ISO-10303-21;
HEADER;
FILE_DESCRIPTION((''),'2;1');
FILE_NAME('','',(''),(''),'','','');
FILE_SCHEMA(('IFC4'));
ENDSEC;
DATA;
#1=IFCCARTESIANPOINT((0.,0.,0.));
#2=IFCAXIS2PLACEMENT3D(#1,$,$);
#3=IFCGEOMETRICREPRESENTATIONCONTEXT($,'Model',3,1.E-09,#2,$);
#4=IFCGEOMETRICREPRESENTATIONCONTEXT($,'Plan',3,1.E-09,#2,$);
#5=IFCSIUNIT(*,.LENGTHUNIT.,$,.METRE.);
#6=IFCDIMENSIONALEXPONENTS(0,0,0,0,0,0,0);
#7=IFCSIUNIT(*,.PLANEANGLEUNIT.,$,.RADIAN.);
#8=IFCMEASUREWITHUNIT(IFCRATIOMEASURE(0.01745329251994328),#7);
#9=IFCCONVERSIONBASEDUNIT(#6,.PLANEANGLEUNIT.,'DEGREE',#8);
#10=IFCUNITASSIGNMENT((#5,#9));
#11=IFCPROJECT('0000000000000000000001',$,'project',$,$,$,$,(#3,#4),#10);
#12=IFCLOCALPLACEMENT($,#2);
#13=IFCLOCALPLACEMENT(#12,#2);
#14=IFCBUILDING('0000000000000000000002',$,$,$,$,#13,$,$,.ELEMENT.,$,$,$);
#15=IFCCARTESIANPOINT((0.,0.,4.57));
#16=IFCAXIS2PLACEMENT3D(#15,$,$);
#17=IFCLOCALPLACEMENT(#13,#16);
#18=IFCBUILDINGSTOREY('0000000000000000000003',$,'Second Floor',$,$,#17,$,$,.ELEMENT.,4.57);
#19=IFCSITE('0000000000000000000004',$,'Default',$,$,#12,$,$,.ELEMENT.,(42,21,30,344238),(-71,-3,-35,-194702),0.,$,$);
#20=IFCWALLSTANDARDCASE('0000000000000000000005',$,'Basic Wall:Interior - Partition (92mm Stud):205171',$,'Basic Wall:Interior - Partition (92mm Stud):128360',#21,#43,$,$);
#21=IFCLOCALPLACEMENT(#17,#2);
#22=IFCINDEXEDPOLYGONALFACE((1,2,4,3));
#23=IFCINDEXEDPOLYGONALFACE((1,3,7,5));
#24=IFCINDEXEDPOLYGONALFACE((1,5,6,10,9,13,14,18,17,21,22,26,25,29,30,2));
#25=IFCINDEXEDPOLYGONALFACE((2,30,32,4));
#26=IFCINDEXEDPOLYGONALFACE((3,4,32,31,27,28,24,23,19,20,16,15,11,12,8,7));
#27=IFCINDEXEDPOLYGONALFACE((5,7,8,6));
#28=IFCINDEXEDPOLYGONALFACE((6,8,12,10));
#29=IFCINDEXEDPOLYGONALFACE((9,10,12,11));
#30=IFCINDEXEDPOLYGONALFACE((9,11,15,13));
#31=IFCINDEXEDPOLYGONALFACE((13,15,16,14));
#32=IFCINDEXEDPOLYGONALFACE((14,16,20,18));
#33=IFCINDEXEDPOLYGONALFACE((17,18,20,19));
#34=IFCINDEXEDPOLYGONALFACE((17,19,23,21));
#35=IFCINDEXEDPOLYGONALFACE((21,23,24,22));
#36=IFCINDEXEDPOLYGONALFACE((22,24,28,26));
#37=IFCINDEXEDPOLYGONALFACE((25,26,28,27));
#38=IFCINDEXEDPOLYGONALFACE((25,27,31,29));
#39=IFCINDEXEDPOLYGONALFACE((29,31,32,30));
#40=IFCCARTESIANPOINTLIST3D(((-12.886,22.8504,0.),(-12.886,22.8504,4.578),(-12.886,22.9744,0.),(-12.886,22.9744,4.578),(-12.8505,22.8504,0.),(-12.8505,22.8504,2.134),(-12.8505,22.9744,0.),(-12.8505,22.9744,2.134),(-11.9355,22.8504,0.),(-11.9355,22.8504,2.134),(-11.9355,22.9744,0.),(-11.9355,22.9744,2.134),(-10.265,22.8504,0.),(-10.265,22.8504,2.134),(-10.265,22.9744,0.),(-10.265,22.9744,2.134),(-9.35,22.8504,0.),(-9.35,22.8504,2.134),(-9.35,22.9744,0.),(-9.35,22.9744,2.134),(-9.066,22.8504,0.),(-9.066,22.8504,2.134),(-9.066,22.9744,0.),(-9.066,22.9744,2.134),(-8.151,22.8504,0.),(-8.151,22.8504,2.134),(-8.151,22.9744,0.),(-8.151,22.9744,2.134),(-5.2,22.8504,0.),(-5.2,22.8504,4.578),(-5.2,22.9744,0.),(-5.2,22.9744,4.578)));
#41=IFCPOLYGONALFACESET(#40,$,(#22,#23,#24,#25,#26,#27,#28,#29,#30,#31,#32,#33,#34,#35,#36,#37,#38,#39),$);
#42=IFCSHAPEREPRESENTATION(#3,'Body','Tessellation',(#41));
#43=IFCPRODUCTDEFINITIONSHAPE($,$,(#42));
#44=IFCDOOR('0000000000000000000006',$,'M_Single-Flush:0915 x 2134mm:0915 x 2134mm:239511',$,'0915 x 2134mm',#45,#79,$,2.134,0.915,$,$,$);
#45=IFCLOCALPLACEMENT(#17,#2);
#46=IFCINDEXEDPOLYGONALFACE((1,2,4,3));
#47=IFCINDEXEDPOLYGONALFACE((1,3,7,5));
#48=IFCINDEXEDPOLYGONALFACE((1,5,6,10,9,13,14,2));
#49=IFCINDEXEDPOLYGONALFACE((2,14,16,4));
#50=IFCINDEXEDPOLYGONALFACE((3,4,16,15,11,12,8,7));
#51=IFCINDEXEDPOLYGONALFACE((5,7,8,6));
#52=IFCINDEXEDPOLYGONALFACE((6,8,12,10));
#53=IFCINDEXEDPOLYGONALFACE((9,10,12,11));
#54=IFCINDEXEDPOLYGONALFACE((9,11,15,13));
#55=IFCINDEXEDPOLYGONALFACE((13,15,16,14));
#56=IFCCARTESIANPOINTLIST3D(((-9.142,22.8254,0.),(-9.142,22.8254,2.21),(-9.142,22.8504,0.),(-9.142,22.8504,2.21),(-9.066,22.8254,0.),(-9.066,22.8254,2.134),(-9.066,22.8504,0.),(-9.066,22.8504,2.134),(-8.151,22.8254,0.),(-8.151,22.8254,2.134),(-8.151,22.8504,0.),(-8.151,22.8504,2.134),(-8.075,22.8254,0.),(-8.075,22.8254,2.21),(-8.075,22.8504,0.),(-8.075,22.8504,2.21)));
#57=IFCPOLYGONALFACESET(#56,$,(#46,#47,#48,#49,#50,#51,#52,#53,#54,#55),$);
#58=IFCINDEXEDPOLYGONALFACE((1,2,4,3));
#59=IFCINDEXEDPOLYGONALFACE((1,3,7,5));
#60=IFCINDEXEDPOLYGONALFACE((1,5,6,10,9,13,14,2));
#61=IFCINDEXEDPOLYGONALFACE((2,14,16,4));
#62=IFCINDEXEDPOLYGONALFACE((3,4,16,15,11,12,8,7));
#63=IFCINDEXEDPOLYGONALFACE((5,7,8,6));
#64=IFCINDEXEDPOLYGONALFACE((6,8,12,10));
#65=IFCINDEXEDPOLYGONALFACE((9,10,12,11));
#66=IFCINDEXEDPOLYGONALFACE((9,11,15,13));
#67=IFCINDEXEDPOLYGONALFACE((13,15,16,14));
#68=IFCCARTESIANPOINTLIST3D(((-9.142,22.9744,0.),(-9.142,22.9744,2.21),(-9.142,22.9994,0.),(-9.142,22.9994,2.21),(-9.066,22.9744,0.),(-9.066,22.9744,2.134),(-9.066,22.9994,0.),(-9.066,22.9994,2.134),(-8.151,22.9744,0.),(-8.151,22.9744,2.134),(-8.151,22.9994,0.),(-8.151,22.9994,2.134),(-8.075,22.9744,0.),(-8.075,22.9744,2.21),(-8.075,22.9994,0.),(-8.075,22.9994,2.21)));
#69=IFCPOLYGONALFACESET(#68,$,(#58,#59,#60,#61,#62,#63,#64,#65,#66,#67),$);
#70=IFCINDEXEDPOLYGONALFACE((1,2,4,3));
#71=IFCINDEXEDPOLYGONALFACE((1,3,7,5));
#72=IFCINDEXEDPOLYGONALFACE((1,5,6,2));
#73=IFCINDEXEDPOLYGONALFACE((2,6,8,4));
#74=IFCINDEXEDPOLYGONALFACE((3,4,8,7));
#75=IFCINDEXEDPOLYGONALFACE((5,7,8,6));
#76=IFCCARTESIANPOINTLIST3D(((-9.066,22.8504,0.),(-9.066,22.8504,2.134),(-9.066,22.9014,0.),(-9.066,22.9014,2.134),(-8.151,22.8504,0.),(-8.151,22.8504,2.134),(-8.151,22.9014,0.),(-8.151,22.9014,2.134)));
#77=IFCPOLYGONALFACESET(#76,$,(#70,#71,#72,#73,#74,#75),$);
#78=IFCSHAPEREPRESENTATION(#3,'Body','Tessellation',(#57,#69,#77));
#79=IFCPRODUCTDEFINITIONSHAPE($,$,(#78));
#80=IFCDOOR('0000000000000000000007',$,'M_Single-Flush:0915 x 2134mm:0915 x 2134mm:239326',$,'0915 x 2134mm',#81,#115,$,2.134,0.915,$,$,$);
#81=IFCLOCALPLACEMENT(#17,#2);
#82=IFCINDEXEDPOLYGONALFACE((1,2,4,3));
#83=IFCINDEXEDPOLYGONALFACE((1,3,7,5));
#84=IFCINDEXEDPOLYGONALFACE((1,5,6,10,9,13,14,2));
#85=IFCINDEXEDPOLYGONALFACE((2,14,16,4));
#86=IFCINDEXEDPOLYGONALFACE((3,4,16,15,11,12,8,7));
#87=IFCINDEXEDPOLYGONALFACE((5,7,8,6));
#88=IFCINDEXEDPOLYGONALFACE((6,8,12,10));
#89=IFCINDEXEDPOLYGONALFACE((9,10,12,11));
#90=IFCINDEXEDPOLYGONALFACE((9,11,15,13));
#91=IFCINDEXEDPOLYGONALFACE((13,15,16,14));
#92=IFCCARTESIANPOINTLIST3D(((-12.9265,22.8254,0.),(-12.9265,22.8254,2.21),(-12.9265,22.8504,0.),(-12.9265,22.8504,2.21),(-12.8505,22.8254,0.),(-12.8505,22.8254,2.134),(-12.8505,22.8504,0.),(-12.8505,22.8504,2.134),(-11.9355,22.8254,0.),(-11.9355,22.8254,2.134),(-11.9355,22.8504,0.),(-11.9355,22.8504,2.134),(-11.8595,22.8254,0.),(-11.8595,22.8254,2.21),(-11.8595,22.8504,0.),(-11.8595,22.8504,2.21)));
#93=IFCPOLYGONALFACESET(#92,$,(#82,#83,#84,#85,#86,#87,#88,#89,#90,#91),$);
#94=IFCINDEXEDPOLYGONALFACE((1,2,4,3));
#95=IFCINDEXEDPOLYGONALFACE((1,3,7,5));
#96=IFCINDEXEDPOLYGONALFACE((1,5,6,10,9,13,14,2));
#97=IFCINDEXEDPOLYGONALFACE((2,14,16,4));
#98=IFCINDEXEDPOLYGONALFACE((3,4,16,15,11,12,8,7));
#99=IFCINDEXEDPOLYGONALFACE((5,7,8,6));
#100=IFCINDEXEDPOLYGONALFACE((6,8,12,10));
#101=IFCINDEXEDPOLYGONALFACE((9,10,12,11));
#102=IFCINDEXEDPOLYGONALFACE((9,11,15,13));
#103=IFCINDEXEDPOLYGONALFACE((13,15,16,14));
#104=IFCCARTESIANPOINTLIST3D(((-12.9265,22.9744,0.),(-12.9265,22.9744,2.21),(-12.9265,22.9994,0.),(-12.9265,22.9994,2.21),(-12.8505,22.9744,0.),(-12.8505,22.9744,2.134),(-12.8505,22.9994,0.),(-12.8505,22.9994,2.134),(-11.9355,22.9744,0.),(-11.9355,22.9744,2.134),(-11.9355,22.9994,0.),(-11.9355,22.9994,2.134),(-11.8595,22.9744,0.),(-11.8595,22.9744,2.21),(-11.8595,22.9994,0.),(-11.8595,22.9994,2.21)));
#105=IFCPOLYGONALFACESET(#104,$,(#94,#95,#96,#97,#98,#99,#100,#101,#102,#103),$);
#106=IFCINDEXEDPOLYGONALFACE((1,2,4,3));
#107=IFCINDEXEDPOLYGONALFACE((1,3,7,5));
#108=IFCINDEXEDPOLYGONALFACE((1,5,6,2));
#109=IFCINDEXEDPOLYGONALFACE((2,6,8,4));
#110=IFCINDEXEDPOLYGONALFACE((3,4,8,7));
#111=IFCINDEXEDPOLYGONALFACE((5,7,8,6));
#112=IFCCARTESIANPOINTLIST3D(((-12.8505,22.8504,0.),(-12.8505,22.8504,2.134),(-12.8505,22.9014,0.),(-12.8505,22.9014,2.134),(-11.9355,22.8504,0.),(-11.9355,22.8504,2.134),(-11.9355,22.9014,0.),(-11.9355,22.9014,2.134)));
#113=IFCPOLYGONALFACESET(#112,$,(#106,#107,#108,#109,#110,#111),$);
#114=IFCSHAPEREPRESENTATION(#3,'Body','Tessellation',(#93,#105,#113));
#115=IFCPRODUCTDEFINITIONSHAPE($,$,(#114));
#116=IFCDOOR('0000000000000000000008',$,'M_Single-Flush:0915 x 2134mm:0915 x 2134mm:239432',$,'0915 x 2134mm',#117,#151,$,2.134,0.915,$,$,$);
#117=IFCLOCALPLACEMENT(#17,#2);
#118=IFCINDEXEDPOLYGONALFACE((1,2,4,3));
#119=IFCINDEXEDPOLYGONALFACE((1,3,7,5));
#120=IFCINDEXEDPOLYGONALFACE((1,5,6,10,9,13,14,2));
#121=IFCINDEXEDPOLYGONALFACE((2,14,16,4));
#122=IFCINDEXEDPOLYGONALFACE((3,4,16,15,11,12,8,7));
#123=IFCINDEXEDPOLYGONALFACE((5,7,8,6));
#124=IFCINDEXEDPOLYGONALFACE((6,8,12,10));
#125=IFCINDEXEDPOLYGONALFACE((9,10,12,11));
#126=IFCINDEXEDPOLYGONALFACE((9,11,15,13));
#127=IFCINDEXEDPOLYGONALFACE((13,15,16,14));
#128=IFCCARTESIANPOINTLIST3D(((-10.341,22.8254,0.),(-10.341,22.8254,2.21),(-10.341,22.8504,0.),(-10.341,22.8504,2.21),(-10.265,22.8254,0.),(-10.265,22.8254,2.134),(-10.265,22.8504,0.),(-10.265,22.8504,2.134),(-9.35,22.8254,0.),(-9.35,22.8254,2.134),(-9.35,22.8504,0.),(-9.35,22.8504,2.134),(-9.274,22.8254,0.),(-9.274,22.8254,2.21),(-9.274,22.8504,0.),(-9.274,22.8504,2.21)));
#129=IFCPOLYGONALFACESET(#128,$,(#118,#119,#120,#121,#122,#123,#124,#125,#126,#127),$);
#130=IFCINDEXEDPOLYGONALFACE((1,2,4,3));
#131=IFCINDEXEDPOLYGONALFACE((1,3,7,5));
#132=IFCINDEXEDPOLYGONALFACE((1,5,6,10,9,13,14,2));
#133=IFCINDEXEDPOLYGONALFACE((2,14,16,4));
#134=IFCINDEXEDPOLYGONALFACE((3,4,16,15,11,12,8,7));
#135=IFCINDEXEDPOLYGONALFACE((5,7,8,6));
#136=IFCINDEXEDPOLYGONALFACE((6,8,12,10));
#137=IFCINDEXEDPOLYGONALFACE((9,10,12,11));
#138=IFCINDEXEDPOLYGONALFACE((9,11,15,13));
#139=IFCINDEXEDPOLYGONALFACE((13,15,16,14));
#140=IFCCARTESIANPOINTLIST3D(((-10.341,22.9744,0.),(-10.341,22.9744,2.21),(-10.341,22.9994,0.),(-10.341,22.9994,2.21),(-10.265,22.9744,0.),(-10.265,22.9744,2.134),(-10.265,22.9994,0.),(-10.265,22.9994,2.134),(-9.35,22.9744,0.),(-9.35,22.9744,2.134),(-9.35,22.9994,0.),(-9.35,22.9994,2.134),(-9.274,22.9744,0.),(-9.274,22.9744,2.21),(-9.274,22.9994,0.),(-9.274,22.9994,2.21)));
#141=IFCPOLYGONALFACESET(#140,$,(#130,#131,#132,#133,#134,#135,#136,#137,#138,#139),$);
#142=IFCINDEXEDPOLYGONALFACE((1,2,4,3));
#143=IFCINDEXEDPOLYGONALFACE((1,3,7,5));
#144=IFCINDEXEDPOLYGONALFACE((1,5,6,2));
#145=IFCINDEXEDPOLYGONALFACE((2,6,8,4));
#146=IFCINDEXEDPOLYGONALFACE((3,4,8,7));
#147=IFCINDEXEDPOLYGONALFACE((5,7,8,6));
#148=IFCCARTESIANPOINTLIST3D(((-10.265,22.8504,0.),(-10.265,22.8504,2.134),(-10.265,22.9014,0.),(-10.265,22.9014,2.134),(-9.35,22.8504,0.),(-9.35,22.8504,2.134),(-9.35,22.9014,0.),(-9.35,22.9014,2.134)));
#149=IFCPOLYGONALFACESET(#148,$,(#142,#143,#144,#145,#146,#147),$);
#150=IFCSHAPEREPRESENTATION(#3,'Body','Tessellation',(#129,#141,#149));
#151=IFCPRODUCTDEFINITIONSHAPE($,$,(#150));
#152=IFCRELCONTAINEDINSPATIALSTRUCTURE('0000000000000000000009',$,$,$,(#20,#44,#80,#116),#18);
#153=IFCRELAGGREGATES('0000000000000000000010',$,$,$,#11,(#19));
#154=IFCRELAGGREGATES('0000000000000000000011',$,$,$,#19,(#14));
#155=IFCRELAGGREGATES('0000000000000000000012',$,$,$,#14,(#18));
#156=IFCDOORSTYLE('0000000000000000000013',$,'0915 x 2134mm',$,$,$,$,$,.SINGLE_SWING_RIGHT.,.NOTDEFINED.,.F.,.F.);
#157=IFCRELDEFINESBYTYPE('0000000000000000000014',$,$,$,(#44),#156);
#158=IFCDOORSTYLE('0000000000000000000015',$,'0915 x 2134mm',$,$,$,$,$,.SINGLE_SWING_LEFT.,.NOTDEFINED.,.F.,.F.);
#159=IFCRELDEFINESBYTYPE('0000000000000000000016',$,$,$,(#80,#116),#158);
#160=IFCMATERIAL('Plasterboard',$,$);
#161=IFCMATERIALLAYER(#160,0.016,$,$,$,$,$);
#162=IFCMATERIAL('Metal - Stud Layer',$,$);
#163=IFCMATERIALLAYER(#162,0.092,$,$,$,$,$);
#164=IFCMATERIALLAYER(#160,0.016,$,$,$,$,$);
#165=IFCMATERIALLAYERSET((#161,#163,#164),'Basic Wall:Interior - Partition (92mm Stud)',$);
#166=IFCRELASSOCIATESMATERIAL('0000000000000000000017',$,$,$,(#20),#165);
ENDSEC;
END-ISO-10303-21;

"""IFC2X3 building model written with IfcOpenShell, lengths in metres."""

from ifc_helpers import new_model, entity, si_unit, converted_unit, frame, frame_2d, origin, origin_2d_with_axis, place, context, project, spatial, polyline, rectangle, outline, extrude, source, transform, mapped, material, layer, layer_set, layer_usage, type_object, type_shapes, element, fill, save


model = new_model("IFC2X3")

# Units and contexts
model_context = context("Model", 3, precision=1e-09, world=origin())
plan_context = context("Plan", 3, precision=1e-09, world=origin())
ifc_project = project(units=[si_unit("LENGTHUNIT", "METRE"), converted_unit("PLANEANGLEUNIT", "DEGREE", entity("IfcRatioMeasure", 0.01745329251994328), si_unit("PLANEANGLEUNIT", "RADIAN"), dimensions=[0, 0, 0, 0, 0, 0, 0])], contexts=[model_context, plan_context])

# Site, building, storey
site_placement = place(None, origin())
site = spatial("IfcSite", under=ifc_project, at=site_placement, Name="Default", CompositionType="ELEMENT", RefLatitude=(42, 21, 30, 344238), RefLongitude=(-71, -3, -35, -194702), RefElevation=0.0)
building_placement = place(site_placement, origin())
building = spatial("IfcBuilding", under=site, at=building_placement, CompositionType="ELEMENT")
storey_placement = place(building_placement, frame((0.0, 0.0, 4.57)))
storey = spatial("IfcBuildingStorey", under=building, at=storey_placement, Name="Second Floor", CompositionType="ELEMENT", Elevation=4.57)

# Wall, openings, doors
ifc_material_1 = material(Name="Plasterboard")
ifc_layer_1 = layer(ifc_material_1, 0.016)
ifc_material_2 = material(Name="Metal - Stud Layer")
ifc_layer_2 = layer(ifc_material_2, 0.092)
ifc_layer_3 = layer(ifc_material_1, 0.016)
ifc_layer_set_1 = layer_set([ifc_layer_1, ifc_layer_2, ifc_layer_3], Name="Basic Wall:Interior - Partition (92mm Stud)")
ifc_layer_usage_1 = layer_usage(ifc_layer_set_1, "AXIS2", "NEGATIVE", 0.062)
wall_1_placement = place(storey_placement, frame((-12.886, 22.9124, 0.0)))
wall_1 = element("IfcWallStandardCase", 1, at=wall_1_placement, inside=storey, material=ifc_layer_usage_1, Name="Basic Wall:Interior - Partition (92mm Stud):205171", ObjectType="Basic Wall:Interior - Partition (92mm Stud):128360", context=model_context, shape_type="SweptSolid", body=[
    extrude(rectangle(XDim=7.686, YDim=0.124, at=frame_2d((3.843, 0.0), x_axis=(-1.0, 0.0))), origin(), (0.0, 0.0, 1.0), 4.578),
])
opening_1_placement = place(wall_1_placement, frame((0.9505, 0.062, 0.0)))
opening_1 = element("IfcOpeningElement", 2, at=opening_1_placement, cuts=wall_1, ObjectType="Opening", context=model_context, shape_type="SweptSolid", body=[
    extrude(rectangle(XDim=0.915, YDim=2.134, at=frame_2d((1.067, 0.4575), x_axis=(0.0, -1.0))), frame((0.0, 0.0, 0.0), z_axis=(0.0, -1.0, 0.0), x_axis=(0.0, 0.0, 1.0)), (0.0, 0.0, 1.0), 0.124),
])
opening_2_placement = place(wall_1_placement, frame((4.735, 0.062, 0.0)))
opening_2 = element("IfcOpeningElement", 3, at=opening_2_placement, cuts=wall_1, ObjectType="Opening", context=model_context, shape_type="SweptSolid", body=[
    extrude(rectangle(XDim=0.915, YDim=2.134, at=frame_2d((1.067, 0.4575), x_axis=(0.0, 1.0))), frame((0.0, 0.0, 0.0), z_axis=(0.0, -1.0, 0.0), x_axis=(0.0, 0.0, 1.0)), (0.0, 0.0, 1.0), 0.124),
])
opening_3_placement = place(wall_1_placement, frame((3.536, 0.062, 0.0)))
opening_3 = element("IfcOpeningElement", 4, at=opening_3_placement, cuts=wall_1, ObjectType="Opening", context=model_context, shape_type="SweptSolid", body=[
    extrude(rectangle(XDim=0.915, YDim=2.134, at=frame_2d((1.067, 0.4575), x_axis=(0.0, -1.0))), frame((0.0, 0.0, 0.0), z_axis=(0.0, -1.0, 0.0), x_axis=(0.0, 0.0, 1.0)), (0.0, 0.0, 1.0), 0.124),
])
door_style_1 = type_object("IfcDoorStyle", Name="0915 x 2134mm", ConstructionType="NOTDEFINED", OperationType="SINGLE_SWING_RIGHT", ParameterTakesPrecedence=False, Sizeable=False)
shared_shape_1 = source(origin(), model_context, "Body", "SweptSolid", [
    extrude(outline(polyline([(-0.5335, -1.124), (0.5335, -1.124), (0.5335, 1.086), (0.4575, 1.086), (0.4575, -1.048), (-0.4575, -1.048), (-0.4575, 1.086), (-0.5335, 1.086), (-0.5335, -1.124)])), frame((0.4575, 0.124, 1.086), z_axis=(0.0, 1.0, 0.0), x_axis=(1.0, 0.0, 0.0)), (0.0, 0.0, 1.0), 0.025),
    extrude(outline(polyline([(-1.124, -0.5335), (1.086, -0.5335), (1.086, -0.4575), (-1.048, -0.4575), (-1.048, 0.4575), (1.086, 0.4575), (1.086, 0.5335), (-1.124, 0.5335), (-1.124, -0.5335)])), frame((0.4575, -0.025, 1.086), z_axis=(0.0, 1.0, 0.0), x_axis=(0.0, 0.0, -1.0)), (0.0, 0.0, 1.0), 0.025),
    extrude(rectangle(XDim=0.051, YDim=0.915, at=origin_2d_with_axis()), frame((0.4575, 0.0985, 0.0), z_axis=(0.0, 0.0, 1.0), x_axis=(0.0, 1.0, 0.0)), (0.0, 0.0, 1.0), 2.134),
])
type_shapes(door_style_1, [shared_shape_1])
door_1_placement = place(opening_2_placement, frame((0.0, 0.0, 0.0), z_axis=(0.0, 0.0, 1.0), x_axis=(-1.0, 0.0, 0.0)))
door_1 = element("IfcDoor", 5, at=door_1_placement, inside=storey, type_object=door_style_1, Name="M_Single-Flush:0915 x 2134mm:0915 x 2134mm:239511", ObjectType="0915 x 2134mm", OverallHeight=2.134, OverallWidth=0.915, context=model_context, shape_type="MappedRepresentation", body=[
    mapped(shared_shape_1, transform((0.0, 0.0, 0.0), scale=1.0)),
])
fill(opening_2, door_1)
door_style_2 = type_object("IfcDoorStyle", Name="0915 x 2134mm", ConstructionType="NOTDEFINED", OperationType="SINGLE_SWING_LEFT", ParameterTakesPrecedence=False, Sizeable=False)
shared_shape_2 = source(origin(), model_context, "Body", "SweptSolid", [
    extrude(outline(polyline([(-0.5335, -1.124), (0.5335, -1.124), (0.5335, 1.086), (0.4575, 1.086), (0.4575, -1.048), (-0.4575, -1.048), (-0.4575, 1.086), (-0.5335, 1.086), (-0.5335, -1.124)])), frame((0.4575, 0.149, 1.086), z_axis=(0.0, -1.0, 0.0), x_axis=(-1.0, 0.0, 0.0)), (0.0, 0.0, 1.0), 0.025),
    extrude(outline(polyline([(-1.124, -0.5335), (1.086, -0.5335), (1.086, -0.4575), (-1.048, -0.4575), (-1.048, 0.4575), (1.086, 0.4575), (1.086, 0.5335), (-1.124, 0.5335), (-1.124, -0.5335)])), frame((0.4575, 0.0, 1.086), z_axis=(0.0, -1.0, 0.0), x_axis=(0.0, 0.0, -1.0)), (0.0, 0.0, 1.0), 0.025),
    extrude(rectangle(XDim=0.915, YDim=0.051, at=origin_2d_with_axis()), frame((0.4575, 0.0985, 0.0)), (0.0, 0.0, 1.0), 2.134),
])
type_shapes(door_style_2, [shared_shape_2])
door_2_placement = place(opening_1_placement, frame((0.0, 0.0, 0.0), z_axis=(0.0, 0.0, 1.0), x_axis=(-1.0, 0.0, 0.0)))
door_2 = element("IfcDoor", 6, at=door_2_placement, inside=storey, type_object=door_style_2, Name="M_Single-Flush:0915 x 2134mm:0915 x 2134mm:239326", ObjectType="0915 x 2134mm", OverallHeight=2.134, OverallWidth=0.915, context=model_context, shape_type="MappedRepresentation", body=[
    mapped(shared_shape_2, transform((0.0, 0.0, 0.0), scale=1.0)),
])
fill(opening_1, door_2)
door_3_placement = place(opening_3_placement, frame((0.0, 0.0, 0.0), z_axis=(0.0, 0.0, 1.0), x_axis=(-1.0, 0.0, 0.0)))
door_3 = element("IfcDoor", 7, at=door_3_placement, inside=storey, type_object=door_style_2, Name="M_Single-Flush:0915 x 2134mm:0915 x 2134mm:239432", ObjectType="0915 x 2134mm", OverallHeight=2.134, OverallWidth=0.915, context=model_context, shape_type="MappedRepresentation", body=[
    mapped(shared_shape_2, transform((0.0, 0.0, 0.0), scale=1.0)),
])
fill(opening_3, door_3)

save(model, "model.ifc")
